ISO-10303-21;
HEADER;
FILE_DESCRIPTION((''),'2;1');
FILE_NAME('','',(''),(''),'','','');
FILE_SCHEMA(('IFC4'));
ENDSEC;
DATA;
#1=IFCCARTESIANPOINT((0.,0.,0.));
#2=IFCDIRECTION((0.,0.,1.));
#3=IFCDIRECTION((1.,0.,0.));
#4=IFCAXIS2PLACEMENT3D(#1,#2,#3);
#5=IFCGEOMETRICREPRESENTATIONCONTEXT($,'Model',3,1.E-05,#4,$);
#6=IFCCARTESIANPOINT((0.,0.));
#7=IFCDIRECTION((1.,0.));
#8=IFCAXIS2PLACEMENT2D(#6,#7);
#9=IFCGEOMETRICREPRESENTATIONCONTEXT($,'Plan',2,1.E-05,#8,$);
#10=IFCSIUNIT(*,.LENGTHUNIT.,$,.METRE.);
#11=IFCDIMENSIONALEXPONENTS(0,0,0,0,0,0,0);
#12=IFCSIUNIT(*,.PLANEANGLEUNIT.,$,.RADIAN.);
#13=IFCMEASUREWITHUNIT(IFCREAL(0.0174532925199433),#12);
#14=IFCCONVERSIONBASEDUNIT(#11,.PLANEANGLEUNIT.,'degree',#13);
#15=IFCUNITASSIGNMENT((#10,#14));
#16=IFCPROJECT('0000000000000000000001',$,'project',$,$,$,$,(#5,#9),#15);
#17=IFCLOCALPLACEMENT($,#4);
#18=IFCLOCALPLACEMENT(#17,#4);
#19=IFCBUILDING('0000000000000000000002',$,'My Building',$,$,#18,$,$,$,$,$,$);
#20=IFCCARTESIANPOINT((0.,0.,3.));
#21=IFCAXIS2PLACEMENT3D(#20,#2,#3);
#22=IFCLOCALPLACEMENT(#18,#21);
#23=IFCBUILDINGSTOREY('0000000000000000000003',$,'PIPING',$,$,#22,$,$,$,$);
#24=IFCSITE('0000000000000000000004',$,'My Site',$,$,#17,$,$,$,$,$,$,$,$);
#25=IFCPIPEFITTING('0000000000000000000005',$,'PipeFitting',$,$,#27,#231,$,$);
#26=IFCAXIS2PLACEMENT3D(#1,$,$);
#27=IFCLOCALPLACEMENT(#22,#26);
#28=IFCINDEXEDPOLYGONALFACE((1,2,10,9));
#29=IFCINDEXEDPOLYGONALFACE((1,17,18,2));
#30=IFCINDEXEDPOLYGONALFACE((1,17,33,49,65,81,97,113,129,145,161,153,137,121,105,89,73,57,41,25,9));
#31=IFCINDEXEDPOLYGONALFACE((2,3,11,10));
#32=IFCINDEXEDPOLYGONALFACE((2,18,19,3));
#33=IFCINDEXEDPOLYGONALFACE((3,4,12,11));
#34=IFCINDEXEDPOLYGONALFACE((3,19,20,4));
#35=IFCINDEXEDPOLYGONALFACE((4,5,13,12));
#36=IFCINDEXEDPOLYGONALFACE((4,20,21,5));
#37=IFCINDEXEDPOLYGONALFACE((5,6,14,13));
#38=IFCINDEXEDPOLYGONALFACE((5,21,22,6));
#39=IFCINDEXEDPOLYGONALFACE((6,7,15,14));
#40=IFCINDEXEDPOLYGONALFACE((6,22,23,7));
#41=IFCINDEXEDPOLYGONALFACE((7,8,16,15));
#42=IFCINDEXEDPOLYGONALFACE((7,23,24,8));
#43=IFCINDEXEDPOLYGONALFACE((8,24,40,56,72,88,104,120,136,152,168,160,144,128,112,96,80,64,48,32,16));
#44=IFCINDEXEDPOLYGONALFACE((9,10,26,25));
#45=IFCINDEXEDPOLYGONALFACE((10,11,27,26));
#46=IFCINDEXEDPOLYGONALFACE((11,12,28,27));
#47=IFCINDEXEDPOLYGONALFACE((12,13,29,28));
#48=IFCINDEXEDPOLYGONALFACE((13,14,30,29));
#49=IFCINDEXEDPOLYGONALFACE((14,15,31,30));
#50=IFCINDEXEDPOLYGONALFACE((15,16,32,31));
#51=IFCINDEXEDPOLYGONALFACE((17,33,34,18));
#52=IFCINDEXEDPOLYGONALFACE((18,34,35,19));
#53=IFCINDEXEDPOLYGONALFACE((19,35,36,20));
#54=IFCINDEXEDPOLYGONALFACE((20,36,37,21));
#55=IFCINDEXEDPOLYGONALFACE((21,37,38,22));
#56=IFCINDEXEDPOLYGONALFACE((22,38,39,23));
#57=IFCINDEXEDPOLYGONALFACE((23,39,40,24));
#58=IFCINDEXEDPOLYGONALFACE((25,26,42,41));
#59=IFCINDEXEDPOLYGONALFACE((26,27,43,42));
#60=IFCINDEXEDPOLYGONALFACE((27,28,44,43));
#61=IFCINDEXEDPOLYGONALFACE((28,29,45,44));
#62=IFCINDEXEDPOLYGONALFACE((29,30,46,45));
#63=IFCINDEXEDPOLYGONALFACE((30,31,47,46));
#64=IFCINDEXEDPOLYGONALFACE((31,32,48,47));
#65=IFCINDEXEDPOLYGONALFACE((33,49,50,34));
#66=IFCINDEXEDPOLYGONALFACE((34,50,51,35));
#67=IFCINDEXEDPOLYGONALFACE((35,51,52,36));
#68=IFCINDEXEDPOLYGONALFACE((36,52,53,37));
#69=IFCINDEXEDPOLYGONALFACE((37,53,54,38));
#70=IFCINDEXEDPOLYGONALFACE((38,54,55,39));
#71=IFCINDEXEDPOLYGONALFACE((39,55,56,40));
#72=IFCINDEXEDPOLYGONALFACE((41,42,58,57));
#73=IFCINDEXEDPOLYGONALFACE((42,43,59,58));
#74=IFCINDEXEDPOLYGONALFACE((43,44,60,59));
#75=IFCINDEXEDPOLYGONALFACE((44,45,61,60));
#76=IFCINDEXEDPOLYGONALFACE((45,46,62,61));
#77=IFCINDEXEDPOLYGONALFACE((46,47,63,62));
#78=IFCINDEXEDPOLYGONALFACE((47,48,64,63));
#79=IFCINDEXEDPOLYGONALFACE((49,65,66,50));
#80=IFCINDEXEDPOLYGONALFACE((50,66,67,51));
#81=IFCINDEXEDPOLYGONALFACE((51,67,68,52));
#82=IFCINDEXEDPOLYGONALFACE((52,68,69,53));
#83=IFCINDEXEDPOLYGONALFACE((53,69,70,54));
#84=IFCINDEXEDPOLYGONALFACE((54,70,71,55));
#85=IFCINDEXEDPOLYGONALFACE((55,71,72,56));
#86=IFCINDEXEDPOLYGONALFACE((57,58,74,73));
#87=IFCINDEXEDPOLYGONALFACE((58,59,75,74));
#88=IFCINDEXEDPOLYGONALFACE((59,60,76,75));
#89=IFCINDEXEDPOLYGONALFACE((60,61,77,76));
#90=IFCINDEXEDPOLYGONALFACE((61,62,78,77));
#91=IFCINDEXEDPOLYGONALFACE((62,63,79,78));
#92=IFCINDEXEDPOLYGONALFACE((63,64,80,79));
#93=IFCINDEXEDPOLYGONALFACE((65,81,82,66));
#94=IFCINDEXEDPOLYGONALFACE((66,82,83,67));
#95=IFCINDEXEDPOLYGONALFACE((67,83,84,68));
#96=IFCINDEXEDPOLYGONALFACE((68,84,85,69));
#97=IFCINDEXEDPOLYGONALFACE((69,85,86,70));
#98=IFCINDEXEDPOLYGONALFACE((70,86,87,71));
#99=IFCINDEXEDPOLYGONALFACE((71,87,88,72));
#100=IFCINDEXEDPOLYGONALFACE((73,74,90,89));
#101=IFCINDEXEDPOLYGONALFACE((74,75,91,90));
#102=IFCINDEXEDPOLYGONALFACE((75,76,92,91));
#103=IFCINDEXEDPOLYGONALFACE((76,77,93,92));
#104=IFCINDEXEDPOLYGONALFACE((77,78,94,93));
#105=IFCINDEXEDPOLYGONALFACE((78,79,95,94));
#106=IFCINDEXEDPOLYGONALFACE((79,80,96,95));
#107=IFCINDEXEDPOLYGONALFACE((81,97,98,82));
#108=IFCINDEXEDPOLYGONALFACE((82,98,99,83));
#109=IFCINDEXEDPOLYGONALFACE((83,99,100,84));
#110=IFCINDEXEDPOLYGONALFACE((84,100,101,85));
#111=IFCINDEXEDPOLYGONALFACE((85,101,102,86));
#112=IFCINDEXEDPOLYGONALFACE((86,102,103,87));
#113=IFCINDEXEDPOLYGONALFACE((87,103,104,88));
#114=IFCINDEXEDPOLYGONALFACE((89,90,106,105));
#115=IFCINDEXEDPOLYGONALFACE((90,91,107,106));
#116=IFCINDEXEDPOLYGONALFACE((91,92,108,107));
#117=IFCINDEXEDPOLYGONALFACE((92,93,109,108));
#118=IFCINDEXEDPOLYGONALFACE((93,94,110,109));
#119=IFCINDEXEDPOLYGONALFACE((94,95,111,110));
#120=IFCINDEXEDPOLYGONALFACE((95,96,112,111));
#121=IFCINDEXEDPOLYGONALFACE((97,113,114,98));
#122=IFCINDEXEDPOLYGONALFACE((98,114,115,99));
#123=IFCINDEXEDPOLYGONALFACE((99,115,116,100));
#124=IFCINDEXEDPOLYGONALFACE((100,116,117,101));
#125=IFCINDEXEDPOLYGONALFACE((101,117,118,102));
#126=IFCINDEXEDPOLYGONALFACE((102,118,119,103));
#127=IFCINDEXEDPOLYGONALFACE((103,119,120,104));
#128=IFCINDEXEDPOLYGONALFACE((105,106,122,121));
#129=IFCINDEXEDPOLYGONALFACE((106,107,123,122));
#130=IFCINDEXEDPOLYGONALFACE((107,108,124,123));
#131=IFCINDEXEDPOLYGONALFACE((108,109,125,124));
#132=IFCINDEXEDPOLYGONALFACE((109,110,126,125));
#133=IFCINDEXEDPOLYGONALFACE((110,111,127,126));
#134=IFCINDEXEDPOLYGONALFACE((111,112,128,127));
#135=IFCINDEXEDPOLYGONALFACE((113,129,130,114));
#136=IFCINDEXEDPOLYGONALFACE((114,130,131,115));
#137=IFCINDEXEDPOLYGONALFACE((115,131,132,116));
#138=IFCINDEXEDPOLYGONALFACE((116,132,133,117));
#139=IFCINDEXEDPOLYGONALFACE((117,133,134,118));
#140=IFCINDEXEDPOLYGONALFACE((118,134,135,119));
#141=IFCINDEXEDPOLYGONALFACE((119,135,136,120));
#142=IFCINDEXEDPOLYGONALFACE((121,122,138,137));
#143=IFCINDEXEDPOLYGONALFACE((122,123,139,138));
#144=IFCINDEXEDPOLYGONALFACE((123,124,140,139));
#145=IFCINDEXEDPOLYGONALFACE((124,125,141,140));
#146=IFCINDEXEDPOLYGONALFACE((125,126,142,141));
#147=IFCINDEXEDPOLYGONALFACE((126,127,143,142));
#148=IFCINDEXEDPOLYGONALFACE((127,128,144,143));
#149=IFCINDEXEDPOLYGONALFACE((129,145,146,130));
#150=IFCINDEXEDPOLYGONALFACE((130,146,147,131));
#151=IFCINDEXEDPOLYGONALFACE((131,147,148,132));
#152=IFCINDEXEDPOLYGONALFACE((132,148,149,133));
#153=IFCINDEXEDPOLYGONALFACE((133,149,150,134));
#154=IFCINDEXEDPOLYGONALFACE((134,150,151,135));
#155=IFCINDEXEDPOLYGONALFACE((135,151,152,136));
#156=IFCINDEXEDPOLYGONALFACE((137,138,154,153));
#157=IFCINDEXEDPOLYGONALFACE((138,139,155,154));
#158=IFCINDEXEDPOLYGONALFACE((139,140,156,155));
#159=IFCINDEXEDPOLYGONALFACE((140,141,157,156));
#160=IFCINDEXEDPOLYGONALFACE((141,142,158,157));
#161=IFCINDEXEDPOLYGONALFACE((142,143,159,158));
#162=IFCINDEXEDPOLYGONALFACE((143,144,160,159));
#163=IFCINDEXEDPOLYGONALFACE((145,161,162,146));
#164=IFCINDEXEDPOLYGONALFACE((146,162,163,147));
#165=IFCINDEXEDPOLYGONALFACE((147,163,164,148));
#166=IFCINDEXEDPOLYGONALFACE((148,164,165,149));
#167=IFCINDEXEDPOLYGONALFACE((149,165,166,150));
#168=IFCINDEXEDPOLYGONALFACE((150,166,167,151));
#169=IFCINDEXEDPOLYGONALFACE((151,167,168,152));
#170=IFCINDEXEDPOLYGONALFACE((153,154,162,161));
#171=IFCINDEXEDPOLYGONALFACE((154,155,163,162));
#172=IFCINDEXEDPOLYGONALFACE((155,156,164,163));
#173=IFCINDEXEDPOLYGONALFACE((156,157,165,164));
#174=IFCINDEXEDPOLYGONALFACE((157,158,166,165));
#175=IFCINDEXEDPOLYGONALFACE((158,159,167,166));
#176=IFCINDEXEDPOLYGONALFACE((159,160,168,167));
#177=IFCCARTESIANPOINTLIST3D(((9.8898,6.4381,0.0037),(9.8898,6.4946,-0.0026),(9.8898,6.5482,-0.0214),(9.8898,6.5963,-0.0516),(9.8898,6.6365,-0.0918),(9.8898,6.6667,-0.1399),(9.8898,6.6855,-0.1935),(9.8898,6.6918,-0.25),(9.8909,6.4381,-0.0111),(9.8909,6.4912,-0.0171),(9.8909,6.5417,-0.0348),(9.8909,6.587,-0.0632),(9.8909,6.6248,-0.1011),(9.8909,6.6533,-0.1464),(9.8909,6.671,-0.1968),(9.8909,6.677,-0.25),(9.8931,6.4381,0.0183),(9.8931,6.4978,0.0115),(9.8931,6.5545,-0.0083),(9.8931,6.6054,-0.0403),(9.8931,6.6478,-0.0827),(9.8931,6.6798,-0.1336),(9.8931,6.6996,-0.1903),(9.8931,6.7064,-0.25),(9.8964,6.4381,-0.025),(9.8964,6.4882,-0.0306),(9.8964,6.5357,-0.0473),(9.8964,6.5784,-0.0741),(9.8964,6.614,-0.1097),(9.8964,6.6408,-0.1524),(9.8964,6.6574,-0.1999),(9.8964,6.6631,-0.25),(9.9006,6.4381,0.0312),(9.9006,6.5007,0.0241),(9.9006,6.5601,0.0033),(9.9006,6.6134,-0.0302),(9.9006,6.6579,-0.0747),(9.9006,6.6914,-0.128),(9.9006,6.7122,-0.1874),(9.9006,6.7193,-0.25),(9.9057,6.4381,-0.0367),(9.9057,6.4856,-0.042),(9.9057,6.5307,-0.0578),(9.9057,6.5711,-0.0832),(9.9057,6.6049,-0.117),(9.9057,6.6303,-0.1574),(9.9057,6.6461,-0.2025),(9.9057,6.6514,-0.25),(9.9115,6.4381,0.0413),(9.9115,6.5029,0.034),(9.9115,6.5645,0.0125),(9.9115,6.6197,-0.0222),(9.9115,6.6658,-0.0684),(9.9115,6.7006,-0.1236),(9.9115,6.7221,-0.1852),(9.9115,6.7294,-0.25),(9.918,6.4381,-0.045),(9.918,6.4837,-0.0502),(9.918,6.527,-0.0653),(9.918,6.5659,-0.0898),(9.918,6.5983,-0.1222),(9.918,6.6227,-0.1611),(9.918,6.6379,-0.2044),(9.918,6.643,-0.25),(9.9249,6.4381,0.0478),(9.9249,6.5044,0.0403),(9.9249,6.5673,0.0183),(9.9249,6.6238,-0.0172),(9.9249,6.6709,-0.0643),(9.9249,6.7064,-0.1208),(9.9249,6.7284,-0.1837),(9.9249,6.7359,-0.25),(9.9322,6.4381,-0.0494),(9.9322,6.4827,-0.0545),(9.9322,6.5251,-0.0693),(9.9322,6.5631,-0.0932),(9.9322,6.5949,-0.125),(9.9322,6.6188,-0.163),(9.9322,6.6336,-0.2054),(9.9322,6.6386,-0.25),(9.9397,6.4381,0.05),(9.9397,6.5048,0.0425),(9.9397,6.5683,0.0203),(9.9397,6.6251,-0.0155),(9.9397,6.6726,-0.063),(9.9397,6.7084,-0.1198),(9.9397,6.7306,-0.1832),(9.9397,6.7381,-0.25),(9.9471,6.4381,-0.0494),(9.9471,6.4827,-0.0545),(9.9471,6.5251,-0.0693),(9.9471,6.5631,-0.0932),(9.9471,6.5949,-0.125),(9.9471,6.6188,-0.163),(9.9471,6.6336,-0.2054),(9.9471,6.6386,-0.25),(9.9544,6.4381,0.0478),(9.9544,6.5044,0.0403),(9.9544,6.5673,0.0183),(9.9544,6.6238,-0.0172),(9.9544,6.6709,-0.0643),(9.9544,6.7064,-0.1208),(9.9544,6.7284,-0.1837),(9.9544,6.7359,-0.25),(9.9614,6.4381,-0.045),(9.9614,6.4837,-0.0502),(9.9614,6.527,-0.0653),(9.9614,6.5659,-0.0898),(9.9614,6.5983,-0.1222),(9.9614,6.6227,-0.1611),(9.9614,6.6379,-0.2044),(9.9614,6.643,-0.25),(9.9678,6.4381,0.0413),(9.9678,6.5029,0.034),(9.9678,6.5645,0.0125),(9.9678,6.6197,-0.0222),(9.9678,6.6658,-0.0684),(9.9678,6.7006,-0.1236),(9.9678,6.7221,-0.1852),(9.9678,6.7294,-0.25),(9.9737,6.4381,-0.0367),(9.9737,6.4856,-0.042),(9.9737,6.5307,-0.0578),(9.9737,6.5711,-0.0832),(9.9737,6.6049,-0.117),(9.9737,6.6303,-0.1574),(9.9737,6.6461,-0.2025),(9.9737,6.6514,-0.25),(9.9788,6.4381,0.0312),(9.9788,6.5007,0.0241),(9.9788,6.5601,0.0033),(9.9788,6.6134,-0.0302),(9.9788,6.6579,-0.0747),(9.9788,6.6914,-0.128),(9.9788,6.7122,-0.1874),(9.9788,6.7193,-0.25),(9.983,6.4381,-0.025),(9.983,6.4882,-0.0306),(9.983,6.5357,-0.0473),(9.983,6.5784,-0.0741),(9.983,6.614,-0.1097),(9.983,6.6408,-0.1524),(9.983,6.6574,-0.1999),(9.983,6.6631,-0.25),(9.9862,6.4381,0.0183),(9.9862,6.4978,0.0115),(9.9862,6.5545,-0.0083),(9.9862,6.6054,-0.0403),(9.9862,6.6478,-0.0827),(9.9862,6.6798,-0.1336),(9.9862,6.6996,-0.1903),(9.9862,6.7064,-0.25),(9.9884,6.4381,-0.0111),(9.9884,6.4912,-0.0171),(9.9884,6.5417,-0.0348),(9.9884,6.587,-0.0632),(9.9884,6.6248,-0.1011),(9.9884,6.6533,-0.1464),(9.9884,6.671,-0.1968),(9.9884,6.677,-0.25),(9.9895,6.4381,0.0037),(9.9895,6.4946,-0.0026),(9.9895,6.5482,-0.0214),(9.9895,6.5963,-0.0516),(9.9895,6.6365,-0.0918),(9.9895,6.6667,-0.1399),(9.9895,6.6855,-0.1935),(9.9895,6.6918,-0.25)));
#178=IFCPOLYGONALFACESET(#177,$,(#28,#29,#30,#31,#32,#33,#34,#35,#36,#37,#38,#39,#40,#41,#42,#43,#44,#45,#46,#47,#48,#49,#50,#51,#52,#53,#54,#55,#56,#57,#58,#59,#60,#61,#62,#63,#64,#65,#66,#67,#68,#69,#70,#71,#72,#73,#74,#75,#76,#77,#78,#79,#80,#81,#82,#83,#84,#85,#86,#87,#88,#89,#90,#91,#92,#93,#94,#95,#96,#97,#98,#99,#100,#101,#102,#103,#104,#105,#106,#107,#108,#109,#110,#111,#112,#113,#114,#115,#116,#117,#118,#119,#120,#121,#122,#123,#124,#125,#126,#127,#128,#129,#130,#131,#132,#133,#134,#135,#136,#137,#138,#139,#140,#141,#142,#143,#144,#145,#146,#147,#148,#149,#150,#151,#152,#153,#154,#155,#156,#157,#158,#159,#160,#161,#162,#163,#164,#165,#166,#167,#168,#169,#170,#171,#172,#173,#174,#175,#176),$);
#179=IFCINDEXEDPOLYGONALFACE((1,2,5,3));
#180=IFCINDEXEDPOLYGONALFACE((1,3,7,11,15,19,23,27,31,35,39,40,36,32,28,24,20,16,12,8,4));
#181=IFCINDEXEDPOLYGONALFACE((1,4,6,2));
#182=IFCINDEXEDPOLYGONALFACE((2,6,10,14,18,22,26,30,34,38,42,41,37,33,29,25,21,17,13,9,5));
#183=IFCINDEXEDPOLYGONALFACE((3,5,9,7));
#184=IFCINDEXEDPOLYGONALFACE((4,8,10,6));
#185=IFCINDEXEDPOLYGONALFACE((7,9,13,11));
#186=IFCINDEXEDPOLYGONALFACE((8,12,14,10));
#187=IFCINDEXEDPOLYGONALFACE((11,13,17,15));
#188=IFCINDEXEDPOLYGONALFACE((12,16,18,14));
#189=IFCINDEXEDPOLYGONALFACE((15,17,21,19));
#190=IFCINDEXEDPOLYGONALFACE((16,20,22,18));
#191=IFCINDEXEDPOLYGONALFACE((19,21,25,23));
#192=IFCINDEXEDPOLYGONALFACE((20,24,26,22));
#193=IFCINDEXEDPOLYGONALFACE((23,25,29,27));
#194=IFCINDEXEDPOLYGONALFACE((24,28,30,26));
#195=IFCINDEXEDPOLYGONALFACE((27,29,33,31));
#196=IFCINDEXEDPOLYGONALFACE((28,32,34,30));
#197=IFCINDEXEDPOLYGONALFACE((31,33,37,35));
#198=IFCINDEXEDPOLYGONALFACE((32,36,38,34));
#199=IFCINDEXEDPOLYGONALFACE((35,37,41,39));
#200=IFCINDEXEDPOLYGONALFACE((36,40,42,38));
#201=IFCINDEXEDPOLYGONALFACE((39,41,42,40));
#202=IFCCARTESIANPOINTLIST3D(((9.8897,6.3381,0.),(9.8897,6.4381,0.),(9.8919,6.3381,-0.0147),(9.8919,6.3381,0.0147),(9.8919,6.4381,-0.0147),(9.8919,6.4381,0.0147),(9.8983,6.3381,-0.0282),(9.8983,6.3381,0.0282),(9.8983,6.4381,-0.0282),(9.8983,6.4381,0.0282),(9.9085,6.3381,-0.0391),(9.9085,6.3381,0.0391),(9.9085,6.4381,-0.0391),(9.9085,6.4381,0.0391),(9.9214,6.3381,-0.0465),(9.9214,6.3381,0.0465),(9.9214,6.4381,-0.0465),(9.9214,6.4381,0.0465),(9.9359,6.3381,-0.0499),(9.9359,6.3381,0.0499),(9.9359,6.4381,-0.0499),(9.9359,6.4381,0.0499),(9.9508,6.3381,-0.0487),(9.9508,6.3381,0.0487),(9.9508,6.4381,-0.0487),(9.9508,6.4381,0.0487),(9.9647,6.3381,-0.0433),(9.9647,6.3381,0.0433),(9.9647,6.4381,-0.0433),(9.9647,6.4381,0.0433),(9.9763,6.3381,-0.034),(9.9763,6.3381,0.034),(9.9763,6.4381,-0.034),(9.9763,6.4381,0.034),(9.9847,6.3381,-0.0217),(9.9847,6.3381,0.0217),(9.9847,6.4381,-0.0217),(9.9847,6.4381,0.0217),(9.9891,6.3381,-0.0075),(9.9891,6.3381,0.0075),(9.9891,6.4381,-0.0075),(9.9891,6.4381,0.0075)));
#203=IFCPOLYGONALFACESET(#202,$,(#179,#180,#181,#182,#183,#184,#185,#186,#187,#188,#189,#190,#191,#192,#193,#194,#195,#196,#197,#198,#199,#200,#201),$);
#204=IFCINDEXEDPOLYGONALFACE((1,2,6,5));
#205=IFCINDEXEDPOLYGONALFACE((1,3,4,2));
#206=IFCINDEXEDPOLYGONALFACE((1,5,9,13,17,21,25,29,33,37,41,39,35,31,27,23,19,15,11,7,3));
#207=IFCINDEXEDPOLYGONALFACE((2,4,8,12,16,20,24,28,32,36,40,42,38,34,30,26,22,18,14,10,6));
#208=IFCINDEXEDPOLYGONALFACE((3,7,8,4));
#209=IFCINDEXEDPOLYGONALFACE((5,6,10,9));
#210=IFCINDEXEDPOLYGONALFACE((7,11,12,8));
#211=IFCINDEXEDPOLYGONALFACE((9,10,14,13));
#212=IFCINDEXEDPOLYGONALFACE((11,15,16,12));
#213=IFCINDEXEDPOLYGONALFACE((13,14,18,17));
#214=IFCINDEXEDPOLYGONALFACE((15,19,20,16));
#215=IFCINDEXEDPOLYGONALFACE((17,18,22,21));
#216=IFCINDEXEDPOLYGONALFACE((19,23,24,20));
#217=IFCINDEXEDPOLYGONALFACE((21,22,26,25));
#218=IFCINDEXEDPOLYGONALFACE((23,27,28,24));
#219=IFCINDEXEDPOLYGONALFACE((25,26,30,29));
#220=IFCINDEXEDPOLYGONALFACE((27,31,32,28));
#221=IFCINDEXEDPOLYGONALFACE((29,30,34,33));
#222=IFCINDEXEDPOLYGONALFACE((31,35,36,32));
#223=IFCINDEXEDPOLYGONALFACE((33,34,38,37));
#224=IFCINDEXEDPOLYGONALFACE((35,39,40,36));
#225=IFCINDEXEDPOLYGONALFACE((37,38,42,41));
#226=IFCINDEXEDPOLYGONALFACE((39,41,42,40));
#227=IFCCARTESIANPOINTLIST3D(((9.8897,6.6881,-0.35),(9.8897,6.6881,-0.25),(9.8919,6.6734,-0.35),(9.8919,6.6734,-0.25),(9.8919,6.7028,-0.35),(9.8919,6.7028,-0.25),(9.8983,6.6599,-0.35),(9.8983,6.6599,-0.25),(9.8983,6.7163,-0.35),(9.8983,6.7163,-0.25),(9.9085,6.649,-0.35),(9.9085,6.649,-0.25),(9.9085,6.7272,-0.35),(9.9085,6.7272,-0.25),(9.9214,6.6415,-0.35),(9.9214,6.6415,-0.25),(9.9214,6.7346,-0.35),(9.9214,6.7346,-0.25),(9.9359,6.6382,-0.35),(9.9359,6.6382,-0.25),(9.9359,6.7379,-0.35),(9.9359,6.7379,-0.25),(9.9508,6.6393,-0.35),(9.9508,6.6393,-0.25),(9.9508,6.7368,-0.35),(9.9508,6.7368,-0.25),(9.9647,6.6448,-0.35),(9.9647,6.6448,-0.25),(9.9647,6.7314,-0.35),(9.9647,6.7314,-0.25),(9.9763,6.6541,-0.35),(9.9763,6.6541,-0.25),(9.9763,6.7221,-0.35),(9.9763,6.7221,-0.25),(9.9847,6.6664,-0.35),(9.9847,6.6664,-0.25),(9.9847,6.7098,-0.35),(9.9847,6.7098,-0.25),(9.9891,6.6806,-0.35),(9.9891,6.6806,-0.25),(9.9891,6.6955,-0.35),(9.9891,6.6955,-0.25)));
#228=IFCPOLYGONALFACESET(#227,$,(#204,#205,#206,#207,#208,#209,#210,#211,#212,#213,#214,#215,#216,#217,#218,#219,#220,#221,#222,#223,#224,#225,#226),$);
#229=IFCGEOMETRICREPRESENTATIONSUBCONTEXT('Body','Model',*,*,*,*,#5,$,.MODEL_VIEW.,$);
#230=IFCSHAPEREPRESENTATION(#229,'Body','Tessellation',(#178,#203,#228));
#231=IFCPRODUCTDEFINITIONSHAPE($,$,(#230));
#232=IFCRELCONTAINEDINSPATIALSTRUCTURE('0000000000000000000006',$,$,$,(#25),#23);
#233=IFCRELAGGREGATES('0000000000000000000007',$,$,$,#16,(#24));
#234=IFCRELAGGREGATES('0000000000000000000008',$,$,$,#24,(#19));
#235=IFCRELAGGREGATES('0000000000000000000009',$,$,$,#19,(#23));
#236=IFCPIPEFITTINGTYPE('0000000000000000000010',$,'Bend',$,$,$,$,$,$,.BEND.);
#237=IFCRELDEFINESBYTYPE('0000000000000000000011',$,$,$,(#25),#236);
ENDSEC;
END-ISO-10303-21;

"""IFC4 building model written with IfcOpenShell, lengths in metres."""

from ifc_helpers import new_model, entity, si_unit, converted_unit, frame, origin_with_axes, origin_2d_with_axis, place, context, subcontext, project, spatial, circle, extrude, source, transform, mapped, type_object, type_shapes, element, save


model = new_model("IFC4")

# Units and contexts
model_context = context("Model", 3, precision=1e-05, world=origin_with_axes())
plan_context = context("Plan", 2, precision=1e-05, world=origin_2d_with_axis())
body_context = subcontext(model_context, "Body", "Model", "MODEL_VIEW")
ifc_project = project(units=[si_unit("LENGTHUNIT", "METRE"), converted_unit("PLANEANGLEUNIT", "degree", entity("IfcReal", 0.0174532925199433), si_unit("PLANEANGLEUNIT", "RADIAN"), dimensions=[0, 0, 0, 0, 0, 0, 0])], contexts=[model_context, plan_context])

# Site, building, storey
site_placement = place(None, origin_with_axes())
site = spatial("IfcSite", under=ifc_project, at=site_placement, Name="My Site")
building_placement = place(site_placement, origin_with_axes())
building = spatial("IfcBuilding", under=site, at=building_placement, Name="My Building")
storey_placement = place(building_placement, frame((0.0, 0.0, 3.0), z_axis=(0.0, 0.0, 1.0), x_axis=(1.0, 0.0, 0.0)))
storey = spatial("IfcBuildingStorey", under=building, at=storey_placement, Name="PIPING")

# Pipe fitting
pipe_fitting_type = type_object("IfcPipeFittingType", Name="Bend", PredefinedType="BEND")
shared_shape = source(origin_with_axes(), body_context, "Body", "SolidModel", [
    entity("IfcSweptDiskSolid", entity("IfcIndexedPolyCurve", entity("IfcCartesianPointList3D", [[0.0, 0.0, 0.1], [0.0, -0.0732, 0.2768], [0.0, -0.25, 0.35]]), [entity("IfcArcIndex", [1, 2, 3])]), 0.05),
    extrude(circle(Radius=0.05), origin_with_axes(), (0.0, 0.0, 1.0), 0.1),
    extrude(circle(Radius=0.05), frame((0.0, -0.25, 0.35), z_axis=(0.0, -1.0, 0.0), x_axis=(1.0, 0.0, 0.0)), (0.0, 0.0, 1.0), 0.1),
])
type_shapes(pipe_fitting_type, [shared_shape])
for number, where, z_axis, x_axis, name in (
    (1, (9.9397, 6.3381, 0.0), (0.0, 1.0, 0.0), (-1.0, 0.0, 0.0), "PipeFitting"),
):
    element("IfcPipeFitting", number, at=place(storey_placement, frame(where, z_axis=z_axis, x_axis=x_axis)), inside=storey, type_object=pipe_fitting_type, Name=name, context=body_context, shape_type="MappedRepresentation", body=[
        mapped(shared_shape, transform((0.0, 0.0, 0.0), x_axis=(1.0, 0.0, 0.0), y_axis=(0.0, 1.0, 0.0), z_axis=(0.0, 0.0, 1.0), scale=1.0)),
    ])

save(model, "model.ifc")
